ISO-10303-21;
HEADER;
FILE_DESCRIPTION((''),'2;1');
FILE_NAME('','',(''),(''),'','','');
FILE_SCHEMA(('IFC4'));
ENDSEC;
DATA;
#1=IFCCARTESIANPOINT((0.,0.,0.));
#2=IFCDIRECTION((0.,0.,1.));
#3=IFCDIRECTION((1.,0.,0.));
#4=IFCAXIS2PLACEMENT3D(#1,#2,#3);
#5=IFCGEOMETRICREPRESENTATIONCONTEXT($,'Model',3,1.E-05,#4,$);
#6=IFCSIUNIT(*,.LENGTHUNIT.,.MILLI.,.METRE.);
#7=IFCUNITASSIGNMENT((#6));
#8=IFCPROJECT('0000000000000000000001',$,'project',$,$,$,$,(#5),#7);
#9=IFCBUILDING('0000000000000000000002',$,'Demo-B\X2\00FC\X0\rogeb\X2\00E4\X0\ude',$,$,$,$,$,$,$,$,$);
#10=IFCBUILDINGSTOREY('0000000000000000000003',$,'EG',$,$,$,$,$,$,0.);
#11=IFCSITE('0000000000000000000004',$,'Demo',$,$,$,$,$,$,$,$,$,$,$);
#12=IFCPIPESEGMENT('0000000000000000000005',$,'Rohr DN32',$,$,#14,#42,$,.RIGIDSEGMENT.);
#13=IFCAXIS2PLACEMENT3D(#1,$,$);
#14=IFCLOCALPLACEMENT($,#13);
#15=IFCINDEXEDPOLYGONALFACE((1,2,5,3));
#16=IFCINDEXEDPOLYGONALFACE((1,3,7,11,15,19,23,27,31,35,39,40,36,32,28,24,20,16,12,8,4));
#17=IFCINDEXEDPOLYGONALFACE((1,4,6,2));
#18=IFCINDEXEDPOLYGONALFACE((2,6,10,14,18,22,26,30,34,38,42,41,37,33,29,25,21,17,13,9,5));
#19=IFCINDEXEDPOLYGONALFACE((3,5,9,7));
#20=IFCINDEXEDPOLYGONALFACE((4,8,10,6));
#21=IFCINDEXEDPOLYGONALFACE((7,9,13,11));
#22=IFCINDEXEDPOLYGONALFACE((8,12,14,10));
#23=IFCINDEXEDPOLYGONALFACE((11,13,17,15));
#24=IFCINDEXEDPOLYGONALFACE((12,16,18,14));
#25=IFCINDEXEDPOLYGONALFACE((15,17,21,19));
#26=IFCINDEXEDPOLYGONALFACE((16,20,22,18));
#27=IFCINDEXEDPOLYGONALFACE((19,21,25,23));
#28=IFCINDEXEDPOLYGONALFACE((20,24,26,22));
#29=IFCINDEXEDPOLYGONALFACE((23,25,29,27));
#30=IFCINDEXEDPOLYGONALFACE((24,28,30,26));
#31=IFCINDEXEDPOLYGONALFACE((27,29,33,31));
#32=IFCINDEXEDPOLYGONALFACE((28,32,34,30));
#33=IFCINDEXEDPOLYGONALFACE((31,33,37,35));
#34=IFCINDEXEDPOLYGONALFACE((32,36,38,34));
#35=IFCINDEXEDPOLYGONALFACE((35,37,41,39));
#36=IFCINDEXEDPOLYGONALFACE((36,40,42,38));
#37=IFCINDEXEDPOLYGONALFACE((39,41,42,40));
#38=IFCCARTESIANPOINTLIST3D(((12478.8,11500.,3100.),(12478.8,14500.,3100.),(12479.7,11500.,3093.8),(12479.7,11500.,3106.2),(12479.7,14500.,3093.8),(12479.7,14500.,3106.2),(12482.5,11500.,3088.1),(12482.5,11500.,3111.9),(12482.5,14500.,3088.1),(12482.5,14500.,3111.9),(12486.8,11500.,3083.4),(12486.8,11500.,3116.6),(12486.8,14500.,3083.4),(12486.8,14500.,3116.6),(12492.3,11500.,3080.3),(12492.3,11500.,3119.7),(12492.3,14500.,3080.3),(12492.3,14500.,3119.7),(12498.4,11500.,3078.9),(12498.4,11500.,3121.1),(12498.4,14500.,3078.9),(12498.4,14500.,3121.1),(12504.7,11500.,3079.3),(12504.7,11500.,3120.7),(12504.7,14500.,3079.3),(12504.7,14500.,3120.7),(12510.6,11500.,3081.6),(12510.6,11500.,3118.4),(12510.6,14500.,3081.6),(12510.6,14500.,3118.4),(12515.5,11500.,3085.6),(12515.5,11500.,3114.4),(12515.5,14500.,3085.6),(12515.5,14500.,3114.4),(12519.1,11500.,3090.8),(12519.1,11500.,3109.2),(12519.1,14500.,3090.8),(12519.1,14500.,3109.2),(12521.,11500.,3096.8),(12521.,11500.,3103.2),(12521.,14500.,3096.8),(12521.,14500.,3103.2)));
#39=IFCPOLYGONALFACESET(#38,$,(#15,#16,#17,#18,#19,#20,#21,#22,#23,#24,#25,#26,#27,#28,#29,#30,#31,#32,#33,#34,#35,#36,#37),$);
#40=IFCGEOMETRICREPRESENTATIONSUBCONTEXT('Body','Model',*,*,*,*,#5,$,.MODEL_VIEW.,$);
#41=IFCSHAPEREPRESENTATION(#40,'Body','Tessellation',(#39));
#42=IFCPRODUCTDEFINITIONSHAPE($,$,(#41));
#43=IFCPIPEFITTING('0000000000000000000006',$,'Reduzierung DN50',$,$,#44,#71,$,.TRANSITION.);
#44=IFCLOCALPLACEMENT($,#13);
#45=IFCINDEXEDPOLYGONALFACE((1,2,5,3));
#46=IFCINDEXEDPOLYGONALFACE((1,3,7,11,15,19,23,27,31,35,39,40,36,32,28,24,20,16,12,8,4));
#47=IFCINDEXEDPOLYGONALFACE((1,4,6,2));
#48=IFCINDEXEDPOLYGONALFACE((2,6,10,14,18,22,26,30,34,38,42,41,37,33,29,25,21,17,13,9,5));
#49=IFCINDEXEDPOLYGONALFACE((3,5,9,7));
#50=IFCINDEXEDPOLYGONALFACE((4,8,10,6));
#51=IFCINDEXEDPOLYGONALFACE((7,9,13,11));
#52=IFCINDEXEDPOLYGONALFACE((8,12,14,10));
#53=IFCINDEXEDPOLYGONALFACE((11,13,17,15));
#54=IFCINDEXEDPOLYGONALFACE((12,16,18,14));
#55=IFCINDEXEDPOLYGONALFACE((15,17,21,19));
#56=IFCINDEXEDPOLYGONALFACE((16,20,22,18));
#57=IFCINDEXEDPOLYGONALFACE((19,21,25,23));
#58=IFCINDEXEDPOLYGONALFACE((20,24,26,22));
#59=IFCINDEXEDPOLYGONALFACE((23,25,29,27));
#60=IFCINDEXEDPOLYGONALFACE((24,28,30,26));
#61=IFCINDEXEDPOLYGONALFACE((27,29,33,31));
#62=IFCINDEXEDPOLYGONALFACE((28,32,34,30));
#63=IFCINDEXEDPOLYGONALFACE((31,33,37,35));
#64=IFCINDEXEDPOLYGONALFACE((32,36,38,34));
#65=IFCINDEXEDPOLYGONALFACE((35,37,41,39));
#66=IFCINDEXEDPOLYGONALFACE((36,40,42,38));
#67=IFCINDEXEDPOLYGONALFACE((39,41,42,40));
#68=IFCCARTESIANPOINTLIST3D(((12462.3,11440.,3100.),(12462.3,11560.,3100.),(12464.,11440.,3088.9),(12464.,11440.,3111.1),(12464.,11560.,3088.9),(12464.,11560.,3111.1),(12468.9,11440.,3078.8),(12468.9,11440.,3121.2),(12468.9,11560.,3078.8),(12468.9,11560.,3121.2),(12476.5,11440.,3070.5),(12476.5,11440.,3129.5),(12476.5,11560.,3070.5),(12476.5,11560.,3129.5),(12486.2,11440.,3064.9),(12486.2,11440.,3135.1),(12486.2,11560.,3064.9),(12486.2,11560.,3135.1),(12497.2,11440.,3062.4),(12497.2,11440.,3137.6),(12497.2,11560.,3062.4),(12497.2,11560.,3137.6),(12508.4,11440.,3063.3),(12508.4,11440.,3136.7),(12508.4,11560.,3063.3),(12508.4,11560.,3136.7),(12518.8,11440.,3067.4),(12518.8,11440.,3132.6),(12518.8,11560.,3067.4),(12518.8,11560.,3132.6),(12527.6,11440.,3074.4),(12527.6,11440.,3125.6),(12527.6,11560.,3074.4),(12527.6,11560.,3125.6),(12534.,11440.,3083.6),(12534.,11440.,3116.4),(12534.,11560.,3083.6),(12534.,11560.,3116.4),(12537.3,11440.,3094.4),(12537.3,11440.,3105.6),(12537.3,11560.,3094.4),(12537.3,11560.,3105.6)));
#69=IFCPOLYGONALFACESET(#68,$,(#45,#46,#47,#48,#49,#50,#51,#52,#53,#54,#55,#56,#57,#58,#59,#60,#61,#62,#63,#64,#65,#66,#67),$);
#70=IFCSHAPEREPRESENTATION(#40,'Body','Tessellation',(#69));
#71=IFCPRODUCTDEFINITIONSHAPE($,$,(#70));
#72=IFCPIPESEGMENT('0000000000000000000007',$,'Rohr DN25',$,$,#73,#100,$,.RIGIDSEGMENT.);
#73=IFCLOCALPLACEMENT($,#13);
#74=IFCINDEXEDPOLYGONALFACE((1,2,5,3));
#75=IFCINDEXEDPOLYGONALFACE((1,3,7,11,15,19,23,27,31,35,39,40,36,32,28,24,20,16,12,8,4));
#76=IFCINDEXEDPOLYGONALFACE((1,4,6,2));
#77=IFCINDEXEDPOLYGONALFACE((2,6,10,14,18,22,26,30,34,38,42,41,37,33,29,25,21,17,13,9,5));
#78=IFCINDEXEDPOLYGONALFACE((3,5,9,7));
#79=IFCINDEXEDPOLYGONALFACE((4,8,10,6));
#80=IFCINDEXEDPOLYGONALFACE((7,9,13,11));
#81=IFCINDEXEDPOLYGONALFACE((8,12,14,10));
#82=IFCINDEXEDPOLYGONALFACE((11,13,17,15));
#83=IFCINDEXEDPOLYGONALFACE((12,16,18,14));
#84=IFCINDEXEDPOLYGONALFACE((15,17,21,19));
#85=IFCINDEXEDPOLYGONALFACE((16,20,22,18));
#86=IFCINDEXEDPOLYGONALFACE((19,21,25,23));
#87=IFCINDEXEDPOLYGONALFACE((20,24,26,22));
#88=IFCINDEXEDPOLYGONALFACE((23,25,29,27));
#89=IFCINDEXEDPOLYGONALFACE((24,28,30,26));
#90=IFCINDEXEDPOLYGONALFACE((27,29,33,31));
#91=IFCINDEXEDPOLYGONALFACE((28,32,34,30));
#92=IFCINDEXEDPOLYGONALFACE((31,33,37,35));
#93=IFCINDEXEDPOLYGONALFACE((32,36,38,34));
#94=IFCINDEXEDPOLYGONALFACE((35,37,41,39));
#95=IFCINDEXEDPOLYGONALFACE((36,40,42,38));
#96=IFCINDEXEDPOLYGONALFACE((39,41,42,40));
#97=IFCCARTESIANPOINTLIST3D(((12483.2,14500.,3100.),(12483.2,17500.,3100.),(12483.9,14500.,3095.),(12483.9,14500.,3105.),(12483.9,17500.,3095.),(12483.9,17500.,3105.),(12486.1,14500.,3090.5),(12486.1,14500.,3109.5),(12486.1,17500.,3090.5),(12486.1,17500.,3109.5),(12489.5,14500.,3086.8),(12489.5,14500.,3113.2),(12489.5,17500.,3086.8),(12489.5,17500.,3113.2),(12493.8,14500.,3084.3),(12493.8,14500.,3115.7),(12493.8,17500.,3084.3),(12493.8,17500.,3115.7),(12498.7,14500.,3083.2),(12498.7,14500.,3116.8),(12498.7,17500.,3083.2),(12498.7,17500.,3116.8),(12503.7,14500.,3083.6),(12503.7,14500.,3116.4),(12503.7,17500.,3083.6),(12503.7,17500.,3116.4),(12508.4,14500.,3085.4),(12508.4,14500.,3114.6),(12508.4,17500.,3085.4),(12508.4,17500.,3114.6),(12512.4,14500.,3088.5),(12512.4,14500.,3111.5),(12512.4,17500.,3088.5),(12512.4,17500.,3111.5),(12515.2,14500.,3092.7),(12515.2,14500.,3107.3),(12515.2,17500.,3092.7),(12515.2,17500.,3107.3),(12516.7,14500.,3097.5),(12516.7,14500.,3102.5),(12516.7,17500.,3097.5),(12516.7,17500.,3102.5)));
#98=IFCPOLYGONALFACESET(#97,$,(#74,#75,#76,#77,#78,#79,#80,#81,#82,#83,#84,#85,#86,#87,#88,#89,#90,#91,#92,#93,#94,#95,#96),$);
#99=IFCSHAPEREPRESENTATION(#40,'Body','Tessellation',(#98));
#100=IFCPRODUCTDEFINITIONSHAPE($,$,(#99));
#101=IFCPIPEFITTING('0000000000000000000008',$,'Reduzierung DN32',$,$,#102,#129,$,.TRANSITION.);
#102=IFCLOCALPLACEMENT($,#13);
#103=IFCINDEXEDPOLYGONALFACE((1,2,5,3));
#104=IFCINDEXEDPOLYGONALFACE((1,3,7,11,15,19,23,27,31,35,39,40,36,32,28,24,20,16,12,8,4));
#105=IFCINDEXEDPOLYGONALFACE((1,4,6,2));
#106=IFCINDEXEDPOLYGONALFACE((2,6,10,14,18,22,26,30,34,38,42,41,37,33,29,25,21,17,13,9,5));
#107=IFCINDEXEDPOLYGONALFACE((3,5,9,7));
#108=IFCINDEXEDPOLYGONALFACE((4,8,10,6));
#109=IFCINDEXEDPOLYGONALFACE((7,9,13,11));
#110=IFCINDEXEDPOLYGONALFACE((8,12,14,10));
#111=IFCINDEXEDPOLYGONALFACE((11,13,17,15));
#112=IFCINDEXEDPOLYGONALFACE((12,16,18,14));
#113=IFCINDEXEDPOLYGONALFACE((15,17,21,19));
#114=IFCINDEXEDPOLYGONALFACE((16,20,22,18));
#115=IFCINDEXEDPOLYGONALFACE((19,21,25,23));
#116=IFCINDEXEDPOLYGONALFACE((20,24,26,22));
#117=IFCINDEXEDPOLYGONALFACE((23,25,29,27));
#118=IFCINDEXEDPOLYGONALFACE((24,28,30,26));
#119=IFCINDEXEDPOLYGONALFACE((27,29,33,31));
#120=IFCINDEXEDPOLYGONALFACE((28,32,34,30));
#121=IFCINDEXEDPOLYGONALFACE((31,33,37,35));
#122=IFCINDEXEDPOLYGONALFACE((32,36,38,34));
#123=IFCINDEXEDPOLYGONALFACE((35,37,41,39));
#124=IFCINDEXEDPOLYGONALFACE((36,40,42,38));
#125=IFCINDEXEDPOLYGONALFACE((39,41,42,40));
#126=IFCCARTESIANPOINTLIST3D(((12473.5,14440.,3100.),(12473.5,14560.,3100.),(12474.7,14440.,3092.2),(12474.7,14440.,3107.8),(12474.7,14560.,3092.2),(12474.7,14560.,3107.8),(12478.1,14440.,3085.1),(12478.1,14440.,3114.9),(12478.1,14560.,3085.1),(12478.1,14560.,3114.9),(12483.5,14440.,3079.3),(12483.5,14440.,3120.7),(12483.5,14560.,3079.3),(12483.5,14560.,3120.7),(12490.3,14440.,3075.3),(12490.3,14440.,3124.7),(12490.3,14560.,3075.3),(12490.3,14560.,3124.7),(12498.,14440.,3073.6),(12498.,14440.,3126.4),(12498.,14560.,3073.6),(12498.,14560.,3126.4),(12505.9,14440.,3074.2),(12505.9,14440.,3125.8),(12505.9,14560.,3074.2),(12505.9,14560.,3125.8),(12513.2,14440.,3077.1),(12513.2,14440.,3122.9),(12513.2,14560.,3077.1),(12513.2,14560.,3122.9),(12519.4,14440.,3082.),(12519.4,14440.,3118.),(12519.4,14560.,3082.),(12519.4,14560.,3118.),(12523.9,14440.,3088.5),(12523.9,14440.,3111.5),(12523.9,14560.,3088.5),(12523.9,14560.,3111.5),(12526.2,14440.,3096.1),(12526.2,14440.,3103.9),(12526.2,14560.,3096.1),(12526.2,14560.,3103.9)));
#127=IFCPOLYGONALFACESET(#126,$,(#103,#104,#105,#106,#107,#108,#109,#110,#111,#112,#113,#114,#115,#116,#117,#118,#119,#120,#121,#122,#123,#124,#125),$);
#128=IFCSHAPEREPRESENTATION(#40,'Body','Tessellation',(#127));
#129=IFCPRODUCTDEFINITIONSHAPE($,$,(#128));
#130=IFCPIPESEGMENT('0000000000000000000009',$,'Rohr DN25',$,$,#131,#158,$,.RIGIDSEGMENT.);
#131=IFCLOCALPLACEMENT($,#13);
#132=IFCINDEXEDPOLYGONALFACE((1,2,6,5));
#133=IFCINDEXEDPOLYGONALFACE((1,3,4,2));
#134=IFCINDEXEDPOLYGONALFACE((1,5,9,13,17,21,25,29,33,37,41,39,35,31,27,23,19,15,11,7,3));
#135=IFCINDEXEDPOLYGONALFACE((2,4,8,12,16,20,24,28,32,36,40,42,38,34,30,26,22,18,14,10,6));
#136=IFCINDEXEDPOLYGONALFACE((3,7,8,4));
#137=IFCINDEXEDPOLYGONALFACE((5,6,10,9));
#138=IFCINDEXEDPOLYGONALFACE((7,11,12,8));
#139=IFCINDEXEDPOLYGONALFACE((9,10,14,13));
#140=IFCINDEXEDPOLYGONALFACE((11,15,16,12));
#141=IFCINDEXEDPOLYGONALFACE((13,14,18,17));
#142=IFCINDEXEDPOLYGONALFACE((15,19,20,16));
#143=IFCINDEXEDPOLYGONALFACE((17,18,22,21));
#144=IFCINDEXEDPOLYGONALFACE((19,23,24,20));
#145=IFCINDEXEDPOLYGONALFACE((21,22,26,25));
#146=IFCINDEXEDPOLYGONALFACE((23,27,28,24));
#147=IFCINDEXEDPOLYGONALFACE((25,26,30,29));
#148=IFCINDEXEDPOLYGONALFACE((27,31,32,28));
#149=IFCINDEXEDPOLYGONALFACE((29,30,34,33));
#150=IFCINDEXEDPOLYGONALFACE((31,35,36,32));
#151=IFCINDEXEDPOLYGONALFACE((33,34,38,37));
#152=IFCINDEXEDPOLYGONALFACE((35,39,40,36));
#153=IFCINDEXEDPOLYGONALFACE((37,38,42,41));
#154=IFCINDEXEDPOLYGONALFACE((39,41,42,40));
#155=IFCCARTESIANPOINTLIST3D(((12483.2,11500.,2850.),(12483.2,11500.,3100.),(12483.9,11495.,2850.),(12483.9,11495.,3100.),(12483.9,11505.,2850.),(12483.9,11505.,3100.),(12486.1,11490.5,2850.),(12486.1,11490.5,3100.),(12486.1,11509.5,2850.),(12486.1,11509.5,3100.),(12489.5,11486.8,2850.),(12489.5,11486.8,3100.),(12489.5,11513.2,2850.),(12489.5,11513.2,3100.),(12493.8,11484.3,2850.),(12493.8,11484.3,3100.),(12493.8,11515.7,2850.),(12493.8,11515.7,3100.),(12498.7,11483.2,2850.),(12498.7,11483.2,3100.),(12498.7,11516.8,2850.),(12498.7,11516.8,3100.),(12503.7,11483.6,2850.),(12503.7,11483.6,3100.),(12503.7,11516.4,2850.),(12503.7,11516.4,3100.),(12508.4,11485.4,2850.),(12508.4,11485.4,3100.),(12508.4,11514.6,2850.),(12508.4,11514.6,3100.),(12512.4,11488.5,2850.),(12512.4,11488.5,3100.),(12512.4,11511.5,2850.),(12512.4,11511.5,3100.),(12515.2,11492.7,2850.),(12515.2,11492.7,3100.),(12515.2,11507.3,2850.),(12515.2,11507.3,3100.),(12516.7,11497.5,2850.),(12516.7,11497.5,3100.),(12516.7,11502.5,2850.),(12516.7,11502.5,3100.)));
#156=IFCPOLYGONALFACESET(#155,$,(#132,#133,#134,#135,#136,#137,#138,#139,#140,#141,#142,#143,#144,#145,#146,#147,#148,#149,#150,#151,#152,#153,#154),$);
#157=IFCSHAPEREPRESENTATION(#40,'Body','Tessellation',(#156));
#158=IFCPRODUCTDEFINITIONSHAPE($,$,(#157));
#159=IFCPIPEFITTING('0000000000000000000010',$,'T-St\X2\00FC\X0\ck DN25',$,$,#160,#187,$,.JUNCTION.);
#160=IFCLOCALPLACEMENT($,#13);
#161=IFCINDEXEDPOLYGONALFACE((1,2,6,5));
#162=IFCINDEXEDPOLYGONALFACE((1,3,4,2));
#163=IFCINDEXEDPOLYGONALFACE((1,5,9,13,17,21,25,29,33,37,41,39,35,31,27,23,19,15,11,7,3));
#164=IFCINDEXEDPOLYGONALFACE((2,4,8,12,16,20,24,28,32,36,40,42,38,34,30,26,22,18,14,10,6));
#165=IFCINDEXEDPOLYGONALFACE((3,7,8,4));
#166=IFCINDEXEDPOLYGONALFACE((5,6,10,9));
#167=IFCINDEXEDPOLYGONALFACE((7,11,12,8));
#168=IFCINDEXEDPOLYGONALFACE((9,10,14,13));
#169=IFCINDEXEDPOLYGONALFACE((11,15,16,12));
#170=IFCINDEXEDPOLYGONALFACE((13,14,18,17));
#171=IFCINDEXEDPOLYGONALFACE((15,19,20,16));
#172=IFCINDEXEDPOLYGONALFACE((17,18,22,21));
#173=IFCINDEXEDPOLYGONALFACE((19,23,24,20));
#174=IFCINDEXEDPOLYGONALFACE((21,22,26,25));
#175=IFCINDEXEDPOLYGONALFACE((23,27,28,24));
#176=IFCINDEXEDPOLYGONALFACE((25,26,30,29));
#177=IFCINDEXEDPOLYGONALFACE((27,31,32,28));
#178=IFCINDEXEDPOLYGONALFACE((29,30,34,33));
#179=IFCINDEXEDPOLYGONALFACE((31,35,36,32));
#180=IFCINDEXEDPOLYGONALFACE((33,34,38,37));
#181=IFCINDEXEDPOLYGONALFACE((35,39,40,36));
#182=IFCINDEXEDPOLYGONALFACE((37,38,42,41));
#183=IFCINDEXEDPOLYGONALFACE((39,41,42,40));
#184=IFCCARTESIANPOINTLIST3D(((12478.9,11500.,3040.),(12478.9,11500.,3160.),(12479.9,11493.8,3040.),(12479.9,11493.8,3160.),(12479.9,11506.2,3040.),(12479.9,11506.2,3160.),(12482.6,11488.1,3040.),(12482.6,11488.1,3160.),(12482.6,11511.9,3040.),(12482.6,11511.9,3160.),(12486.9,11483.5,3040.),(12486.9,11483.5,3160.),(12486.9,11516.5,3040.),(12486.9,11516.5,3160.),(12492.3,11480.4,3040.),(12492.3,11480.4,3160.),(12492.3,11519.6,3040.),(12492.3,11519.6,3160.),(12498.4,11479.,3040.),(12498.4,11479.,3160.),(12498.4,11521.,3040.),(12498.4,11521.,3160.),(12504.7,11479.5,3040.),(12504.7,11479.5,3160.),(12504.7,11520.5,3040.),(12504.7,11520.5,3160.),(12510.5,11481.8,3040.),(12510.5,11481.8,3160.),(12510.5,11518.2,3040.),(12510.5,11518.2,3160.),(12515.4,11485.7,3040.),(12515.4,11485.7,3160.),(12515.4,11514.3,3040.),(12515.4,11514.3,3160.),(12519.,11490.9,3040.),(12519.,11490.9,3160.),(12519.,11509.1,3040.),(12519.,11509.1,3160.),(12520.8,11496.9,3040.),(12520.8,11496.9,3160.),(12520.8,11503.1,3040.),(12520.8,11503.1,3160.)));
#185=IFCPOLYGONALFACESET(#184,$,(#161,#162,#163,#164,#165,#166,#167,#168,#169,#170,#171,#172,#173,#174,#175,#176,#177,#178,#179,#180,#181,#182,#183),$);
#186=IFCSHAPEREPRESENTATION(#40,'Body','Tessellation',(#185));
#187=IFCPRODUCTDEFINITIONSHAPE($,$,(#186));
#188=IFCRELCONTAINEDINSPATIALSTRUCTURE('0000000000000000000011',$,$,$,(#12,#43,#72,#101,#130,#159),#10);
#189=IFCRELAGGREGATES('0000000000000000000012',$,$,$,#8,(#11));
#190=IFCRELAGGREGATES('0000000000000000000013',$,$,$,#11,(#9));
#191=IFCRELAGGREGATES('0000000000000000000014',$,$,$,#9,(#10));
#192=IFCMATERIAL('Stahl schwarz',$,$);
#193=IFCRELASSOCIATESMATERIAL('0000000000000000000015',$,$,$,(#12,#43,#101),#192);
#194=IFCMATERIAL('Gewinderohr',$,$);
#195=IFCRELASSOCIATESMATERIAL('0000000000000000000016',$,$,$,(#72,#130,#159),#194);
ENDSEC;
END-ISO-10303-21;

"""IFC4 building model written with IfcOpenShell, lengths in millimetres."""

from ifc_helpers import new_model, si_unit, frame, origin_with_axes, place, context, subcontext, project, spatial, circle, extrude, material, element, save


model = new_model("IFC4")

# Units and contexts
model_context = context("Model", 3, precision=1e-05, world=origin_with_axes())
body_context = subcontext(model_context, "Body", "Model", "MODEL_VIEW")
ifc_project = project(units=[si_unit("LENGTHUNIT", "METRE", prefix="MILLI")], contexts=[model_context])

# Site, building, storey
site = spatial("IfcSite", under=ifc_project, Name="Demo")
building = spatial("IfcBuilding", under=site, Name="Demo-Bürogebäude")
storey = spatial("IfcBuildingStorey", under=building, Name="EG", Elevation=0.0)

# Pipe segment
ifc_material_1 = material(Name="Stahl schwarz")
pipe_segment_1_placement = place(None, frame((12500.0, 11500.0, 3100.0), z_axis=(0.0, 1.0, 0.0), x_axis=(-1.0, 0.0, 0.0)))
element("IfcPipeSegment", 1, at=pipe_segment_1_placement, inside=storey, material=ifc_material_1, Name="Rohr DN32", PredefinedType="RIGIDSEGMENT", context=body_context, shape_type="SweptSolid", body=[
    extrude(circle(Radius=21.2), origin_with_axes(), (0.0, 0.0, 1.0), 3000.0),
])

# Pipe fitting
pipe_fitting_1_placement = place(None, frame((12500.0, 11440.0, 3100.0), z_axis=(0.0, 1.0, 0.0), x_axis=(-1.0, 0.0, 0.0)))
element("IfcPipeFitting", 2, at=pipe_fitting_1_placement, inside=storey, material=ifc_material_1, Name="Reduzierung DN50", PredefinedType="TRANSITION", context=body_context, shape_type="SweptSolid", body=[
    extrude(circle(Radius=37.7), origin_with_axes(), (0.0, 0.0, 1.0), 120.0),
])

# Pipe segment
ifc_material_2 = material(Name="Gewinderohr")
pipe_segment_2_placement = place(None, frame((12500.0, 14500.0, 3100.0), z_axis=(0.0, 1.0, 0.0), x_axis=(-1.0, 0.0, 0.0)))
element("IfcPipeSegment", 3, at=pipe_segment_2_placement, inside=storey, material=ifc_material_2, Name="Rohr DN25", PredefinedType="RIGIDSEGMENT", context=body_context, shape_type="SweptSolid", body=[
    extrude(circle(Radius=16.9), origin_with_axes(), (0.0, 0.0, 1.0), 3000.0),
])

# Pipe fitting
pipe_fitting_2_placement = place(None, frame((12500.0, 14440.0, 3100.0), z_axis=(0.0, 1.0, 0.0), x_axis=(-1.0, 0.0, 0.0)))
element("IfcPipeFitting", 4, at=pipe_fitting_2_placement, inside=storey, material=ifc_material_1, Name="Reduzierung DN32", PredefinedType="TRANSITION", context=body_context, shape_type="SweptSolid", body=[
    extrude(circle(Radius=26.5), origin_with_axes(), (0.0, 0.0, 1.0), 120.0),
])

# Pipe segment
pipe_segment_3_placement = place(None, frame((12500.0, 11500.0, 3100.0), z_axis=(0.0, 0.0, -1.0), x_axis=(-1.0, 0.0, 0.0)))
element("IfcPipeSegment", 5, at=pipe_segment_3_placement, inside=storey, material=ifc_material_2, Name="Rohr DN25", PredefinedType="RIGIDSEGMENT", context=body_context, shape_type="SweptSolid", body=[
    extrude(circle(Radius=16.9), origin_with_axes(), (0.0, 0.0, 1.0), 250.0),
])

# Pipe fitting
pipe_fitting_3_placement = place(None, frame((12500.0, 11500.0, 3160.0), z_axis=(0.0, 0.0, -1.0), x_axis=(-1.0, 0.0, 0.0)))
element("IfcPipeFitting", 6, at=pipe_fitting_3_placement, inside=storey, material=ifc_material_2, Name="T-Stück DN25", PredefinedType="JUNCTION", context=body_context, shape_type="SweptSolid", body=[
    extrude(circle(Radius=21.1), origin_with_axes(), (0.0, 0.0, 1.0), 120.0),
])

save(model, "model.ifc")
